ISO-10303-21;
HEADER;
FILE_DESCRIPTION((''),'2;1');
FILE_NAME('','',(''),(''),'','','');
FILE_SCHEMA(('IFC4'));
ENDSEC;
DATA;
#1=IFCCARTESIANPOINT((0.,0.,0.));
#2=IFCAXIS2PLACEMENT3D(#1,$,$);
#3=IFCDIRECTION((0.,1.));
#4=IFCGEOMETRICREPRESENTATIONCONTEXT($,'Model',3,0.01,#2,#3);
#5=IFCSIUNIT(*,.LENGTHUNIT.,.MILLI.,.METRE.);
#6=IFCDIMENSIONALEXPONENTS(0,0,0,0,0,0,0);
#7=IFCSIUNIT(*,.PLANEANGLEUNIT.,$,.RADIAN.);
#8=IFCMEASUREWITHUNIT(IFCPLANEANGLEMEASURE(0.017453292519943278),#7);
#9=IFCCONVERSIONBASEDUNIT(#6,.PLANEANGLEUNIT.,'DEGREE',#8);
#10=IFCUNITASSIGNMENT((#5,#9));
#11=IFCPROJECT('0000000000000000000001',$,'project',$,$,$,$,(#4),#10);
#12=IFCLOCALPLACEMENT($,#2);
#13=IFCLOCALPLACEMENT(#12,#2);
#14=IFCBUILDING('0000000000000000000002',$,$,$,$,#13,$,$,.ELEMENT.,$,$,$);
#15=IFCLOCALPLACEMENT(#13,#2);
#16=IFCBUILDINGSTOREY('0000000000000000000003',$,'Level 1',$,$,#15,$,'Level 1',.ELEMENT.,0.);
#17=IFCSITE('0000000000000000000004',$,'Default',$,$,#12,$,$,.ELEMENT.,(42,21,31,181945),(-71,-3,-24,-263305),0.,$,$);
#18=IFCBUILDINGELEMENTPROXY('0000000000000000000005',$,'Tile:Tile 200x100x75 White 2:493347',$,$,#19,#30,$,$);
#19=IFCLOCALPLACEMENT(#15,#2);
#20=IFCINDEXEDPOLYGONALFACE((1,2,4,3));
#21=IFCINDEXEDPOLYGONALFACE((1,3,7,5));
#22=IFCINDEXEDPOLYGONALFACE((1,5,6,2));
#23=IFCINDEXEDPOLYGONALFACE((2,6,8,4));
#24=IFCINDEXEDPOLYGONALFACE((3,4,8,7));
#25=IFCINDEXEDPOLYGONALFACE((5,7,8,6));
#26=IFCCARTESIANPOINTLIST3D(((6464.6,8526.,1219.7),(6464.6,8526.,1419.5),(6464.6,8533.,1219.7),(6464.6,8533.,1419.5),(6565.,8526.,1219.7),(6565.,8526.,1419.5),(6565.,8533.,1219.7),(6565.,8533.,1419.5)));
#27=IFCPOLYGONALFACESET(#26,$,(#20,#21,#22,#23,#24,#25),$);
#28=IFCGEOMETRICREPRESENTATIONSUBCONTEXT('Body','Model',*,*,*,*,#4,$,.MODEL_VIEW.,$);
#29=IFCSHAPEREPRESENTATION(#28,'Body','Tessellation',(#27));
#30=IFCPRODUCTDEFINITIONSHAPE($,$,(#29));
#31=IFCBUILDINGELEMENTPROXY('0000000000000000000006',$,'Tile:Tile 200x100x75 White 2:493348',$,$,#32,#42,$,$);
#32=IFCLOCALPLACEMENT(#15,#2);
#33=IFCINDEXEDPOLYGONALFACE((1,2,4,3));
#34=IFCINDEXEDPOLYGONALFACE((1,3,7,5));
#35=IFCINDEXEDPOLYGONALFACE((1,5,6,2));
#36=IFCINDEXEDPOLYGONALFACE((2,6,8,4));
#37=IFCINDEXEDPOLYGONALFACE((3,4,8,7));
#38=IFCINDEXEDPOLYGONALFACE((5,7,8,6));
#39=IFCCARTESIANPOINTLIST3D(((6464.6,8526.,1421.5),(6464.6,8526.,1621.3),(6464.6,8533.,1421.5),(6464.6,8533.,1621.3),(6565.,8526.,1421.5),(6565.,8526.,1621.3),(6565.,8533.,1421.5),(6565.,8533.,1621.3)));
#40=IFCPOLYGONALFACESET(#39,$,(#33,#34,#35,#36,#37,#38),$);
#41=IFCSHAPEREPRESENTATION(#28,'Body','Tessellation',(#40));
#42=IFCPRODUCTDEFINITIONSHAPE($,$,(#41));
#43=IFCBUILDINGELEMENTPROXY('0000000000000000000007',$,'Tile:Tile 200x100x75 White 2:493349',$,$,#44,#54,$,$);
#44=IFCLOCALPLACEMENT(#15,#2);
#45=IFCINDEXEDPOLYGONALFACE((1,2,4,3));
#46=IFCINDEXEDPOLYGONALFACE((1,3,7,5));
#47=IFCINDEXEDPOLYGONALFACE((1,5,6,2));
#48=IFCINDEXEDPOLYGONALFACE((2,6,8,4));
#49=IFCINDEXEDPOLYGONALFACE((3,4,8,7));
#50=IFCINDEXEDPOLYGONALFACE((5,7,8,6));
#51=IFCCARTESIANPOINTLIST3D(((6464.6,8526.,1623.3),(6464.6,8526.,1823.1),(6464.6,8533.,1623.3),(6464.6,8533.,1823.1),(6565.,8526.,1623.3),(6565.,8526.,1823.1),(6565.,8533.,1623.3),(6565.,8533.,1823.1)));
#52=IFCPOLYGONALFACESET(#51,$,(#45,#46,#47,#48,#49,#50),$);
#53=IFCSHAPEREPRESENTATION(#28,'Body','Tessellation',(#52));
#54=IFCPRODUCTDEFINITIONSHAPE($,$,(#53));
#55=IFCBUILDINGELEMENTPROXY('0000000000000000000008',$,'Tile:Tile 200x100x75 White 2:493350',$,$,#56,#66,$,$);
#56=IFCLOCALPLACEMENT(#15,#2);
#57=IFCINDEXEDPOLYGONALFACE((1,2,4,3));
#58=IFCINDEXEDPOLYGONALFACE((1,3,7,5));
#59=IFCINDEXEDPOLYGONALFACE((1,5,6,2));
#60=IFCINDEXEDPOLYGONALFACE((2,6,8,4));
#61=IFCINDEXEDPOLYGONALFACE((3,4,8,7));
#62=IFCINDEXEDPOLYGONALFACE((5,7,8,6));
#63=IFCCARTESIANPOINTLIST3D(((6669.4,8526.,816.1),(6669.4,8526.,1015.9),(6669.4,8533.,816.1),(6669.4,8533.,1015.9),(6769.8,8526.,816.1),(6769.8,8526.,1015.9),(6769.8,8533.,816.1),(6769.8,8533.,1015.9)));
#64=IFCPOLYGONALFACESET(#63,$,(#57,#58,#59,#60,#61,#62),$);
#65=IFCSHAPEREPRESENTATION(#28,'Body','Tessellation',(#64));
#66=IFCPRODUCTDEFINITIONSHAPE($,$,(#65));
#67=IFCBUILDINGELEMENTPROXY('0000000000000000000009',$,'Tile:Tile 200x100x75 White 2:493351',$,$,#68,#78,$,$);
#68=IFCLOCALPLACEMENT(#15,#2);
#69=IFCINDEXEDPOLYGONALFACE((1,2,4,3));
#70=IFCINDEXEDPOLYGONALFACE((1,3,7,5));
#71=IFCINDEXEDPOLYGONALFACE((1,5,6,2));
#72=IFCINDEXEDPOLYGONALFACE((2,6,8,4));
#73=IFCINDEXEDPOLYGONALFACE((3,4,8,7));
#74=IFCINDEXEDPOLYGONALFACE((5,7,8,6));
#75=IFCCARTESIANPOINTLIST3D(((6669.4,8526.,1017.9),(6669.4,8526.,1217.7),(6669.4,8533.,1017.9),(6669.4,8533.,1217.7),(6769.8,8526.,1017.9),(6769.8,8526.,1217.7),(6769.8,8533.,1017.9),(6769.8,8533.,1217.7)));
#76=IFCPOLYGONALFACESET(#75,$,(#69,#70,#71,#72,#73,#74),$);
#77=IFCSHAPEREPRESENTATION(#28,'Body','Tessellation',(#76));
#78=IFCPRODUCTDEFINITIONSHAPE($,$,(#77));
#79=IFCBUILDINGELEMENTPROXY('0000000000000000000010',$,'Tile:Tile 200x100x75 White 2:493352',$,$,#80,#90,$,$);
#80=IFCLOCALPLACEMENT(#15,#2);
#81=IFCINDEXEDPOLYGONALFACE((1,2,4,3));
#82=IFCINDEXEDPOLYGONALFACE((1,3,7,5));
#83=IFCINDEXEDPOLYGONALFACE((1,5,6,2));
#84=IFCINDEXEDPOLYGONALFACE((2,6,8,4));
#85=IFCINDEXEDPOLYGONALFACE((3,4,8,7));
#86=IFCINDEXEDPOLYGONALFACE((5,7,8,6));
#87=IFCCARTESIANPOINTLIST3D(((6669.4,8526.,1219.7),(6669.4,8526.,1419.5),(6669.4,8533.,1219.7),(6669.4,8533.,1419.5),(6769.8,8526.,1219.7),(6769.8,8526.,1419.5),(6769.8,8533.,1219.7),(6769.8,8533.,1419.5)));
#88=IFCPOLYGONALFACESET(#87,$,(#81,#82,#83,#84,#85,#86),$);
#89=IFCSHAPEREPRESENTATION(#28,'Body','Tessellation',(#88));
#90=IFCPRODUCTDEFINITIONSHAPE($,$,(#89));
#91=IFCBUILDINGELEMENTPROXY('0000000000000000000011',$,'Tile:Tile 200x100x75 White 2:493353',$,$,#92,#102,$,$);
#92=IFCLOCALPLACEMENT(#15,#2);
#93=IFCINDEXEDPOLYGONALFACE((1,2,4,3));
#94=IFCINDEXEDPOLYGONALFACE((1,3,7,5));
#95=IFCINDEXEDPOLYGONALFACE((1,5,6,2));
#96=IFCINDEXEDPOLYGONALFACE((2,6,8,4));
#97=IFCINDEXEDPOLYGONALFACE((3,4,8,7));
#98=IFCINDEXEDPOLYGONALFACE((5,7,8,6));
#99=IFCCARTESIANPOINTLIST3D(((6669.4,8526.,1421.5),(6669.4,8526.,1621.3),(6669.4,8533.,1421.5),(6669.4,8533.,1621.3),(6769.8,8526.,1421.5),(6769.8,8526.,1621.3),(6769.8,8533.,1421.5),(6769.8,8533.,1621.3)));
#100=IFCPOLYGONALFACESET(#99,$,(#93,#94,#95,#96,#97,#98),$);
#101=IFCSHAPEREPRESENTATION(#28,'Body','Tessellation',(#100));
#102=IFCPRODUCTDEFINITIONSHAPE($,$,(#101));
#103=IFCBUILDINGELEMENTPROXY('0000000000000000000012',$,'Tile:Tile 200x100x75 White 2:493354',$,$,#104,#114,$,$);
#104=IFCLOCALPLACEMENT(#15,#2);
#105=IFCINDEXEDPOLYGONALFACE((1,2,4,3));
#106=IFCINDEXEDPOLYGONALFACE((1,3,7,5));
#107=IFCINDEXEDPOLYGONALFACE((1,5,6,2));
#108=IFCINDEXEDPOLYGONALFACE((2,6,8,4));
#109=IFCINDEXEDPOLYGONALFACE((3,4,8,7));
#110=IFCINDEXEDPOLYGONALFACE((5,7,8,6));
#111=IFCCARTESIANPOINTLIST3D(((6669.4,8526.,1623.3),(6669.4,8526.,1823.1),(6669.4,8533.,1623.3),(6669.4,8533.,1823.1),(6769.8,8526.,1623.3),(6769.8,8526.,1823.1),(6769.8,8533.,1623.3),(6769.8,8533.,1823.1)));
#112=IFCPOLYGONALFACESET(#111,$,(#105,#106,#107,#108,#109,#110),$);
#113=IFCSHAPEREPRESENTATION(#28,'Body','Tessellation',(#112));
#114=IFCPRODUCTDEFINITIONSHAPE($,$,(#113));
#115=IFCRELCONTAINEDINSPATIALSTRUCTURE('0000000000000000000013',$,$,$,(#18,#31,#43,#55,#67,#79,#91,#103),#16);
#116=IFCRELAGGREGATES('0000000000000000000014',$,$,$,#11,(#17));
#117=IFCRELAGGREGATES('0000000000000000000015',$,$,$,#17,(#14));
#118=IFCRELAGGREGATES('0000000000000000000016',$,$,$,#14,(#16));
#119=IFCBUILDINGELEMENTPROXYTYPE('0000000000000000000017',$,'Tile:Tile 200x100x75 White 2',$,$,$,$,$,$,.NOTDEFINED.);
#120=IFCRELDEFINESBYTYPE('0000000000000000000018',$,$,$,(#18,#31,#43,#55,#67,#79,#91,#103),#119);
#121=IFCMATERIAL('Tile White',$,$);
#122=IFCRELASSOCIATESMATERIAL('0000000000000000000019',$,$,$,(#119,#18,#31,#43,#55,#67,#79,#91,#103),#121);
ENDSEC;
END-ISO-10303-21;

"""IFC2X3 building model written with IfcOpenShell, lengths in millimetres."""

from ifc_helpers import new_model, entity, si_unit, converted_unit, direction, frame, frame_2d, origin, place, context, subcontext, project, spatial, rectangle, extrude, source, transform, mapped, material, type_object, type_shapes, element, save


model = new_model("IFC2X3")

# Units and contexts
model_context = context("Model", 3, precision=0.01, world=origin(), true_north=direction((0.0, 1.0)))
body_context = subcontext(model_context, "Body", "Model", "MODEL_VIEW")
ifc_project = project(units=[si_unit("LENGTHUNIT", "METRE", prefix="MILLI"), converted_unit("PLANEANGLEUNIT", "DEGREE", entity("IfcPlaneAngleMeasure", 0.017453292519943278), si_unit("PLANEANGLEUNIT", "RADIAN"), dimensions=[0, 0, 0, 0, 0, 0, 0])], contexts=[model_context])

# Site, building, storey
site_placement = place(None, origin())
site = spatial("IfcSite", under=ifc_project, at=site_placement, Name="Default", CompositionType="ELEMENT", RefLatitude=(42, 21, 31, 181945), RefLongitude=(-71, -3, -24, -263305), RefElevation=0.0)
building_placement = place(site_placement, origin())
building = spatial("IfcBuilding", under=site, at=building_placement, CompositionType="ELEMENT")
storey_placement = place(building_placement, origin())
storey = spatial("IfcBuildingStorey", under=building, at=storey_placement, Name="Level 1", LongName="Level 1", CompositionType="ELEMENT", Elevation=0.0)

# Building element proxies
ifc_material = material(Name="Tile White")
building_element_proxy_type_1 = type_object("IfcBuildingElementProxyType", Name="Tile:Tile 200x100x75 White 2", PredefinedType="NOTDEFINED", material=ifc_material)
shared_shape_1 = source(origin(), body_context, "Body", "SweptSolid", [
    extrude(rectangle(XDim=199.8, YDim=100.4, at=frame_2d((0.0, 0.0), x_axis=(1.0, 0.0))), frame((-50.2, -99.9, 0.0), z_axis=(0.0, 0.0, 1.0), x_axis=(0.0, -1.0, 0.0)), (0.0, 0.0, 1.0), 7.0),
])
type_shapes(building_element_proxy_type_1, [shared_shape_1])
for number, where, z_axis, x_axis, name in (
    (1, (6565.0, 8533.0, 1419.5), (0.0, -1.0, 0.0), (1.0, 0.0, 0.0), "Tile:Tile 200x100x75 White 2:493347"),
    (2, (6565.0, 8533.0, 1621.3), (0.0, -1.0, 0.0), (1.0, 0.0, 0.0), "Tile:Tile 200x100x75 White 2:493348"),
    (3, (6565.0, 8533.0, 1823.1), (0.0, -1.0, 0.0), (1.0, 0.0, 0.0), "Tile:Tile 200x100x75 White 2:493349"),
    (4, (6769.8, 8533.0, 1015.9), (0.0, -1.0, 0.0), (1.0, 0.0, 0.0), "Tile:Tile 200x100x75 White 2:493350"),
    (5, (6769.8, 8533.0, 1217.7), (0.0, -1.0, 0.0), (1.0, 0.0, 0.0), "Tile:Tile 200x100x75 White 2:493351"),
    (6, (6769.8, 8533.0, 1419.5), (0.0, -1.0, 0.0), (1.0, 0.0, 0.0), "Tile:Tile 200x100x75 White 2:493352"),
    (7, (6769.8, 8533.0, 1621.3), (0.0, -1.0, 0.0), (1.0, 0.0, 0.0), "Tile:Tile 200x100x75 White 2:493353"),
    (8, (6769.8, 8533.0, 1823.1), (0.0, -1.0, 0.0), (1.0, 0.0, 0.0), "Tile:Tile 200x100x75 White 2:493354"),
):
    element("IfcBuildingElementProxy", number, at=place(storey_placement, frame(where, z_axis=z_axis, x_axis=x_axis)), inside=storey, type_object=building_element_proxy_type_1, material=ifc_material, Name=name, context=body_context, shape_type="MappedRepresentation", body=[
        mapped(shared_shape_1, transform((0.0, 0.0, 0.0), scale=1.0)),
    ])

save(model, "model.ifc")
